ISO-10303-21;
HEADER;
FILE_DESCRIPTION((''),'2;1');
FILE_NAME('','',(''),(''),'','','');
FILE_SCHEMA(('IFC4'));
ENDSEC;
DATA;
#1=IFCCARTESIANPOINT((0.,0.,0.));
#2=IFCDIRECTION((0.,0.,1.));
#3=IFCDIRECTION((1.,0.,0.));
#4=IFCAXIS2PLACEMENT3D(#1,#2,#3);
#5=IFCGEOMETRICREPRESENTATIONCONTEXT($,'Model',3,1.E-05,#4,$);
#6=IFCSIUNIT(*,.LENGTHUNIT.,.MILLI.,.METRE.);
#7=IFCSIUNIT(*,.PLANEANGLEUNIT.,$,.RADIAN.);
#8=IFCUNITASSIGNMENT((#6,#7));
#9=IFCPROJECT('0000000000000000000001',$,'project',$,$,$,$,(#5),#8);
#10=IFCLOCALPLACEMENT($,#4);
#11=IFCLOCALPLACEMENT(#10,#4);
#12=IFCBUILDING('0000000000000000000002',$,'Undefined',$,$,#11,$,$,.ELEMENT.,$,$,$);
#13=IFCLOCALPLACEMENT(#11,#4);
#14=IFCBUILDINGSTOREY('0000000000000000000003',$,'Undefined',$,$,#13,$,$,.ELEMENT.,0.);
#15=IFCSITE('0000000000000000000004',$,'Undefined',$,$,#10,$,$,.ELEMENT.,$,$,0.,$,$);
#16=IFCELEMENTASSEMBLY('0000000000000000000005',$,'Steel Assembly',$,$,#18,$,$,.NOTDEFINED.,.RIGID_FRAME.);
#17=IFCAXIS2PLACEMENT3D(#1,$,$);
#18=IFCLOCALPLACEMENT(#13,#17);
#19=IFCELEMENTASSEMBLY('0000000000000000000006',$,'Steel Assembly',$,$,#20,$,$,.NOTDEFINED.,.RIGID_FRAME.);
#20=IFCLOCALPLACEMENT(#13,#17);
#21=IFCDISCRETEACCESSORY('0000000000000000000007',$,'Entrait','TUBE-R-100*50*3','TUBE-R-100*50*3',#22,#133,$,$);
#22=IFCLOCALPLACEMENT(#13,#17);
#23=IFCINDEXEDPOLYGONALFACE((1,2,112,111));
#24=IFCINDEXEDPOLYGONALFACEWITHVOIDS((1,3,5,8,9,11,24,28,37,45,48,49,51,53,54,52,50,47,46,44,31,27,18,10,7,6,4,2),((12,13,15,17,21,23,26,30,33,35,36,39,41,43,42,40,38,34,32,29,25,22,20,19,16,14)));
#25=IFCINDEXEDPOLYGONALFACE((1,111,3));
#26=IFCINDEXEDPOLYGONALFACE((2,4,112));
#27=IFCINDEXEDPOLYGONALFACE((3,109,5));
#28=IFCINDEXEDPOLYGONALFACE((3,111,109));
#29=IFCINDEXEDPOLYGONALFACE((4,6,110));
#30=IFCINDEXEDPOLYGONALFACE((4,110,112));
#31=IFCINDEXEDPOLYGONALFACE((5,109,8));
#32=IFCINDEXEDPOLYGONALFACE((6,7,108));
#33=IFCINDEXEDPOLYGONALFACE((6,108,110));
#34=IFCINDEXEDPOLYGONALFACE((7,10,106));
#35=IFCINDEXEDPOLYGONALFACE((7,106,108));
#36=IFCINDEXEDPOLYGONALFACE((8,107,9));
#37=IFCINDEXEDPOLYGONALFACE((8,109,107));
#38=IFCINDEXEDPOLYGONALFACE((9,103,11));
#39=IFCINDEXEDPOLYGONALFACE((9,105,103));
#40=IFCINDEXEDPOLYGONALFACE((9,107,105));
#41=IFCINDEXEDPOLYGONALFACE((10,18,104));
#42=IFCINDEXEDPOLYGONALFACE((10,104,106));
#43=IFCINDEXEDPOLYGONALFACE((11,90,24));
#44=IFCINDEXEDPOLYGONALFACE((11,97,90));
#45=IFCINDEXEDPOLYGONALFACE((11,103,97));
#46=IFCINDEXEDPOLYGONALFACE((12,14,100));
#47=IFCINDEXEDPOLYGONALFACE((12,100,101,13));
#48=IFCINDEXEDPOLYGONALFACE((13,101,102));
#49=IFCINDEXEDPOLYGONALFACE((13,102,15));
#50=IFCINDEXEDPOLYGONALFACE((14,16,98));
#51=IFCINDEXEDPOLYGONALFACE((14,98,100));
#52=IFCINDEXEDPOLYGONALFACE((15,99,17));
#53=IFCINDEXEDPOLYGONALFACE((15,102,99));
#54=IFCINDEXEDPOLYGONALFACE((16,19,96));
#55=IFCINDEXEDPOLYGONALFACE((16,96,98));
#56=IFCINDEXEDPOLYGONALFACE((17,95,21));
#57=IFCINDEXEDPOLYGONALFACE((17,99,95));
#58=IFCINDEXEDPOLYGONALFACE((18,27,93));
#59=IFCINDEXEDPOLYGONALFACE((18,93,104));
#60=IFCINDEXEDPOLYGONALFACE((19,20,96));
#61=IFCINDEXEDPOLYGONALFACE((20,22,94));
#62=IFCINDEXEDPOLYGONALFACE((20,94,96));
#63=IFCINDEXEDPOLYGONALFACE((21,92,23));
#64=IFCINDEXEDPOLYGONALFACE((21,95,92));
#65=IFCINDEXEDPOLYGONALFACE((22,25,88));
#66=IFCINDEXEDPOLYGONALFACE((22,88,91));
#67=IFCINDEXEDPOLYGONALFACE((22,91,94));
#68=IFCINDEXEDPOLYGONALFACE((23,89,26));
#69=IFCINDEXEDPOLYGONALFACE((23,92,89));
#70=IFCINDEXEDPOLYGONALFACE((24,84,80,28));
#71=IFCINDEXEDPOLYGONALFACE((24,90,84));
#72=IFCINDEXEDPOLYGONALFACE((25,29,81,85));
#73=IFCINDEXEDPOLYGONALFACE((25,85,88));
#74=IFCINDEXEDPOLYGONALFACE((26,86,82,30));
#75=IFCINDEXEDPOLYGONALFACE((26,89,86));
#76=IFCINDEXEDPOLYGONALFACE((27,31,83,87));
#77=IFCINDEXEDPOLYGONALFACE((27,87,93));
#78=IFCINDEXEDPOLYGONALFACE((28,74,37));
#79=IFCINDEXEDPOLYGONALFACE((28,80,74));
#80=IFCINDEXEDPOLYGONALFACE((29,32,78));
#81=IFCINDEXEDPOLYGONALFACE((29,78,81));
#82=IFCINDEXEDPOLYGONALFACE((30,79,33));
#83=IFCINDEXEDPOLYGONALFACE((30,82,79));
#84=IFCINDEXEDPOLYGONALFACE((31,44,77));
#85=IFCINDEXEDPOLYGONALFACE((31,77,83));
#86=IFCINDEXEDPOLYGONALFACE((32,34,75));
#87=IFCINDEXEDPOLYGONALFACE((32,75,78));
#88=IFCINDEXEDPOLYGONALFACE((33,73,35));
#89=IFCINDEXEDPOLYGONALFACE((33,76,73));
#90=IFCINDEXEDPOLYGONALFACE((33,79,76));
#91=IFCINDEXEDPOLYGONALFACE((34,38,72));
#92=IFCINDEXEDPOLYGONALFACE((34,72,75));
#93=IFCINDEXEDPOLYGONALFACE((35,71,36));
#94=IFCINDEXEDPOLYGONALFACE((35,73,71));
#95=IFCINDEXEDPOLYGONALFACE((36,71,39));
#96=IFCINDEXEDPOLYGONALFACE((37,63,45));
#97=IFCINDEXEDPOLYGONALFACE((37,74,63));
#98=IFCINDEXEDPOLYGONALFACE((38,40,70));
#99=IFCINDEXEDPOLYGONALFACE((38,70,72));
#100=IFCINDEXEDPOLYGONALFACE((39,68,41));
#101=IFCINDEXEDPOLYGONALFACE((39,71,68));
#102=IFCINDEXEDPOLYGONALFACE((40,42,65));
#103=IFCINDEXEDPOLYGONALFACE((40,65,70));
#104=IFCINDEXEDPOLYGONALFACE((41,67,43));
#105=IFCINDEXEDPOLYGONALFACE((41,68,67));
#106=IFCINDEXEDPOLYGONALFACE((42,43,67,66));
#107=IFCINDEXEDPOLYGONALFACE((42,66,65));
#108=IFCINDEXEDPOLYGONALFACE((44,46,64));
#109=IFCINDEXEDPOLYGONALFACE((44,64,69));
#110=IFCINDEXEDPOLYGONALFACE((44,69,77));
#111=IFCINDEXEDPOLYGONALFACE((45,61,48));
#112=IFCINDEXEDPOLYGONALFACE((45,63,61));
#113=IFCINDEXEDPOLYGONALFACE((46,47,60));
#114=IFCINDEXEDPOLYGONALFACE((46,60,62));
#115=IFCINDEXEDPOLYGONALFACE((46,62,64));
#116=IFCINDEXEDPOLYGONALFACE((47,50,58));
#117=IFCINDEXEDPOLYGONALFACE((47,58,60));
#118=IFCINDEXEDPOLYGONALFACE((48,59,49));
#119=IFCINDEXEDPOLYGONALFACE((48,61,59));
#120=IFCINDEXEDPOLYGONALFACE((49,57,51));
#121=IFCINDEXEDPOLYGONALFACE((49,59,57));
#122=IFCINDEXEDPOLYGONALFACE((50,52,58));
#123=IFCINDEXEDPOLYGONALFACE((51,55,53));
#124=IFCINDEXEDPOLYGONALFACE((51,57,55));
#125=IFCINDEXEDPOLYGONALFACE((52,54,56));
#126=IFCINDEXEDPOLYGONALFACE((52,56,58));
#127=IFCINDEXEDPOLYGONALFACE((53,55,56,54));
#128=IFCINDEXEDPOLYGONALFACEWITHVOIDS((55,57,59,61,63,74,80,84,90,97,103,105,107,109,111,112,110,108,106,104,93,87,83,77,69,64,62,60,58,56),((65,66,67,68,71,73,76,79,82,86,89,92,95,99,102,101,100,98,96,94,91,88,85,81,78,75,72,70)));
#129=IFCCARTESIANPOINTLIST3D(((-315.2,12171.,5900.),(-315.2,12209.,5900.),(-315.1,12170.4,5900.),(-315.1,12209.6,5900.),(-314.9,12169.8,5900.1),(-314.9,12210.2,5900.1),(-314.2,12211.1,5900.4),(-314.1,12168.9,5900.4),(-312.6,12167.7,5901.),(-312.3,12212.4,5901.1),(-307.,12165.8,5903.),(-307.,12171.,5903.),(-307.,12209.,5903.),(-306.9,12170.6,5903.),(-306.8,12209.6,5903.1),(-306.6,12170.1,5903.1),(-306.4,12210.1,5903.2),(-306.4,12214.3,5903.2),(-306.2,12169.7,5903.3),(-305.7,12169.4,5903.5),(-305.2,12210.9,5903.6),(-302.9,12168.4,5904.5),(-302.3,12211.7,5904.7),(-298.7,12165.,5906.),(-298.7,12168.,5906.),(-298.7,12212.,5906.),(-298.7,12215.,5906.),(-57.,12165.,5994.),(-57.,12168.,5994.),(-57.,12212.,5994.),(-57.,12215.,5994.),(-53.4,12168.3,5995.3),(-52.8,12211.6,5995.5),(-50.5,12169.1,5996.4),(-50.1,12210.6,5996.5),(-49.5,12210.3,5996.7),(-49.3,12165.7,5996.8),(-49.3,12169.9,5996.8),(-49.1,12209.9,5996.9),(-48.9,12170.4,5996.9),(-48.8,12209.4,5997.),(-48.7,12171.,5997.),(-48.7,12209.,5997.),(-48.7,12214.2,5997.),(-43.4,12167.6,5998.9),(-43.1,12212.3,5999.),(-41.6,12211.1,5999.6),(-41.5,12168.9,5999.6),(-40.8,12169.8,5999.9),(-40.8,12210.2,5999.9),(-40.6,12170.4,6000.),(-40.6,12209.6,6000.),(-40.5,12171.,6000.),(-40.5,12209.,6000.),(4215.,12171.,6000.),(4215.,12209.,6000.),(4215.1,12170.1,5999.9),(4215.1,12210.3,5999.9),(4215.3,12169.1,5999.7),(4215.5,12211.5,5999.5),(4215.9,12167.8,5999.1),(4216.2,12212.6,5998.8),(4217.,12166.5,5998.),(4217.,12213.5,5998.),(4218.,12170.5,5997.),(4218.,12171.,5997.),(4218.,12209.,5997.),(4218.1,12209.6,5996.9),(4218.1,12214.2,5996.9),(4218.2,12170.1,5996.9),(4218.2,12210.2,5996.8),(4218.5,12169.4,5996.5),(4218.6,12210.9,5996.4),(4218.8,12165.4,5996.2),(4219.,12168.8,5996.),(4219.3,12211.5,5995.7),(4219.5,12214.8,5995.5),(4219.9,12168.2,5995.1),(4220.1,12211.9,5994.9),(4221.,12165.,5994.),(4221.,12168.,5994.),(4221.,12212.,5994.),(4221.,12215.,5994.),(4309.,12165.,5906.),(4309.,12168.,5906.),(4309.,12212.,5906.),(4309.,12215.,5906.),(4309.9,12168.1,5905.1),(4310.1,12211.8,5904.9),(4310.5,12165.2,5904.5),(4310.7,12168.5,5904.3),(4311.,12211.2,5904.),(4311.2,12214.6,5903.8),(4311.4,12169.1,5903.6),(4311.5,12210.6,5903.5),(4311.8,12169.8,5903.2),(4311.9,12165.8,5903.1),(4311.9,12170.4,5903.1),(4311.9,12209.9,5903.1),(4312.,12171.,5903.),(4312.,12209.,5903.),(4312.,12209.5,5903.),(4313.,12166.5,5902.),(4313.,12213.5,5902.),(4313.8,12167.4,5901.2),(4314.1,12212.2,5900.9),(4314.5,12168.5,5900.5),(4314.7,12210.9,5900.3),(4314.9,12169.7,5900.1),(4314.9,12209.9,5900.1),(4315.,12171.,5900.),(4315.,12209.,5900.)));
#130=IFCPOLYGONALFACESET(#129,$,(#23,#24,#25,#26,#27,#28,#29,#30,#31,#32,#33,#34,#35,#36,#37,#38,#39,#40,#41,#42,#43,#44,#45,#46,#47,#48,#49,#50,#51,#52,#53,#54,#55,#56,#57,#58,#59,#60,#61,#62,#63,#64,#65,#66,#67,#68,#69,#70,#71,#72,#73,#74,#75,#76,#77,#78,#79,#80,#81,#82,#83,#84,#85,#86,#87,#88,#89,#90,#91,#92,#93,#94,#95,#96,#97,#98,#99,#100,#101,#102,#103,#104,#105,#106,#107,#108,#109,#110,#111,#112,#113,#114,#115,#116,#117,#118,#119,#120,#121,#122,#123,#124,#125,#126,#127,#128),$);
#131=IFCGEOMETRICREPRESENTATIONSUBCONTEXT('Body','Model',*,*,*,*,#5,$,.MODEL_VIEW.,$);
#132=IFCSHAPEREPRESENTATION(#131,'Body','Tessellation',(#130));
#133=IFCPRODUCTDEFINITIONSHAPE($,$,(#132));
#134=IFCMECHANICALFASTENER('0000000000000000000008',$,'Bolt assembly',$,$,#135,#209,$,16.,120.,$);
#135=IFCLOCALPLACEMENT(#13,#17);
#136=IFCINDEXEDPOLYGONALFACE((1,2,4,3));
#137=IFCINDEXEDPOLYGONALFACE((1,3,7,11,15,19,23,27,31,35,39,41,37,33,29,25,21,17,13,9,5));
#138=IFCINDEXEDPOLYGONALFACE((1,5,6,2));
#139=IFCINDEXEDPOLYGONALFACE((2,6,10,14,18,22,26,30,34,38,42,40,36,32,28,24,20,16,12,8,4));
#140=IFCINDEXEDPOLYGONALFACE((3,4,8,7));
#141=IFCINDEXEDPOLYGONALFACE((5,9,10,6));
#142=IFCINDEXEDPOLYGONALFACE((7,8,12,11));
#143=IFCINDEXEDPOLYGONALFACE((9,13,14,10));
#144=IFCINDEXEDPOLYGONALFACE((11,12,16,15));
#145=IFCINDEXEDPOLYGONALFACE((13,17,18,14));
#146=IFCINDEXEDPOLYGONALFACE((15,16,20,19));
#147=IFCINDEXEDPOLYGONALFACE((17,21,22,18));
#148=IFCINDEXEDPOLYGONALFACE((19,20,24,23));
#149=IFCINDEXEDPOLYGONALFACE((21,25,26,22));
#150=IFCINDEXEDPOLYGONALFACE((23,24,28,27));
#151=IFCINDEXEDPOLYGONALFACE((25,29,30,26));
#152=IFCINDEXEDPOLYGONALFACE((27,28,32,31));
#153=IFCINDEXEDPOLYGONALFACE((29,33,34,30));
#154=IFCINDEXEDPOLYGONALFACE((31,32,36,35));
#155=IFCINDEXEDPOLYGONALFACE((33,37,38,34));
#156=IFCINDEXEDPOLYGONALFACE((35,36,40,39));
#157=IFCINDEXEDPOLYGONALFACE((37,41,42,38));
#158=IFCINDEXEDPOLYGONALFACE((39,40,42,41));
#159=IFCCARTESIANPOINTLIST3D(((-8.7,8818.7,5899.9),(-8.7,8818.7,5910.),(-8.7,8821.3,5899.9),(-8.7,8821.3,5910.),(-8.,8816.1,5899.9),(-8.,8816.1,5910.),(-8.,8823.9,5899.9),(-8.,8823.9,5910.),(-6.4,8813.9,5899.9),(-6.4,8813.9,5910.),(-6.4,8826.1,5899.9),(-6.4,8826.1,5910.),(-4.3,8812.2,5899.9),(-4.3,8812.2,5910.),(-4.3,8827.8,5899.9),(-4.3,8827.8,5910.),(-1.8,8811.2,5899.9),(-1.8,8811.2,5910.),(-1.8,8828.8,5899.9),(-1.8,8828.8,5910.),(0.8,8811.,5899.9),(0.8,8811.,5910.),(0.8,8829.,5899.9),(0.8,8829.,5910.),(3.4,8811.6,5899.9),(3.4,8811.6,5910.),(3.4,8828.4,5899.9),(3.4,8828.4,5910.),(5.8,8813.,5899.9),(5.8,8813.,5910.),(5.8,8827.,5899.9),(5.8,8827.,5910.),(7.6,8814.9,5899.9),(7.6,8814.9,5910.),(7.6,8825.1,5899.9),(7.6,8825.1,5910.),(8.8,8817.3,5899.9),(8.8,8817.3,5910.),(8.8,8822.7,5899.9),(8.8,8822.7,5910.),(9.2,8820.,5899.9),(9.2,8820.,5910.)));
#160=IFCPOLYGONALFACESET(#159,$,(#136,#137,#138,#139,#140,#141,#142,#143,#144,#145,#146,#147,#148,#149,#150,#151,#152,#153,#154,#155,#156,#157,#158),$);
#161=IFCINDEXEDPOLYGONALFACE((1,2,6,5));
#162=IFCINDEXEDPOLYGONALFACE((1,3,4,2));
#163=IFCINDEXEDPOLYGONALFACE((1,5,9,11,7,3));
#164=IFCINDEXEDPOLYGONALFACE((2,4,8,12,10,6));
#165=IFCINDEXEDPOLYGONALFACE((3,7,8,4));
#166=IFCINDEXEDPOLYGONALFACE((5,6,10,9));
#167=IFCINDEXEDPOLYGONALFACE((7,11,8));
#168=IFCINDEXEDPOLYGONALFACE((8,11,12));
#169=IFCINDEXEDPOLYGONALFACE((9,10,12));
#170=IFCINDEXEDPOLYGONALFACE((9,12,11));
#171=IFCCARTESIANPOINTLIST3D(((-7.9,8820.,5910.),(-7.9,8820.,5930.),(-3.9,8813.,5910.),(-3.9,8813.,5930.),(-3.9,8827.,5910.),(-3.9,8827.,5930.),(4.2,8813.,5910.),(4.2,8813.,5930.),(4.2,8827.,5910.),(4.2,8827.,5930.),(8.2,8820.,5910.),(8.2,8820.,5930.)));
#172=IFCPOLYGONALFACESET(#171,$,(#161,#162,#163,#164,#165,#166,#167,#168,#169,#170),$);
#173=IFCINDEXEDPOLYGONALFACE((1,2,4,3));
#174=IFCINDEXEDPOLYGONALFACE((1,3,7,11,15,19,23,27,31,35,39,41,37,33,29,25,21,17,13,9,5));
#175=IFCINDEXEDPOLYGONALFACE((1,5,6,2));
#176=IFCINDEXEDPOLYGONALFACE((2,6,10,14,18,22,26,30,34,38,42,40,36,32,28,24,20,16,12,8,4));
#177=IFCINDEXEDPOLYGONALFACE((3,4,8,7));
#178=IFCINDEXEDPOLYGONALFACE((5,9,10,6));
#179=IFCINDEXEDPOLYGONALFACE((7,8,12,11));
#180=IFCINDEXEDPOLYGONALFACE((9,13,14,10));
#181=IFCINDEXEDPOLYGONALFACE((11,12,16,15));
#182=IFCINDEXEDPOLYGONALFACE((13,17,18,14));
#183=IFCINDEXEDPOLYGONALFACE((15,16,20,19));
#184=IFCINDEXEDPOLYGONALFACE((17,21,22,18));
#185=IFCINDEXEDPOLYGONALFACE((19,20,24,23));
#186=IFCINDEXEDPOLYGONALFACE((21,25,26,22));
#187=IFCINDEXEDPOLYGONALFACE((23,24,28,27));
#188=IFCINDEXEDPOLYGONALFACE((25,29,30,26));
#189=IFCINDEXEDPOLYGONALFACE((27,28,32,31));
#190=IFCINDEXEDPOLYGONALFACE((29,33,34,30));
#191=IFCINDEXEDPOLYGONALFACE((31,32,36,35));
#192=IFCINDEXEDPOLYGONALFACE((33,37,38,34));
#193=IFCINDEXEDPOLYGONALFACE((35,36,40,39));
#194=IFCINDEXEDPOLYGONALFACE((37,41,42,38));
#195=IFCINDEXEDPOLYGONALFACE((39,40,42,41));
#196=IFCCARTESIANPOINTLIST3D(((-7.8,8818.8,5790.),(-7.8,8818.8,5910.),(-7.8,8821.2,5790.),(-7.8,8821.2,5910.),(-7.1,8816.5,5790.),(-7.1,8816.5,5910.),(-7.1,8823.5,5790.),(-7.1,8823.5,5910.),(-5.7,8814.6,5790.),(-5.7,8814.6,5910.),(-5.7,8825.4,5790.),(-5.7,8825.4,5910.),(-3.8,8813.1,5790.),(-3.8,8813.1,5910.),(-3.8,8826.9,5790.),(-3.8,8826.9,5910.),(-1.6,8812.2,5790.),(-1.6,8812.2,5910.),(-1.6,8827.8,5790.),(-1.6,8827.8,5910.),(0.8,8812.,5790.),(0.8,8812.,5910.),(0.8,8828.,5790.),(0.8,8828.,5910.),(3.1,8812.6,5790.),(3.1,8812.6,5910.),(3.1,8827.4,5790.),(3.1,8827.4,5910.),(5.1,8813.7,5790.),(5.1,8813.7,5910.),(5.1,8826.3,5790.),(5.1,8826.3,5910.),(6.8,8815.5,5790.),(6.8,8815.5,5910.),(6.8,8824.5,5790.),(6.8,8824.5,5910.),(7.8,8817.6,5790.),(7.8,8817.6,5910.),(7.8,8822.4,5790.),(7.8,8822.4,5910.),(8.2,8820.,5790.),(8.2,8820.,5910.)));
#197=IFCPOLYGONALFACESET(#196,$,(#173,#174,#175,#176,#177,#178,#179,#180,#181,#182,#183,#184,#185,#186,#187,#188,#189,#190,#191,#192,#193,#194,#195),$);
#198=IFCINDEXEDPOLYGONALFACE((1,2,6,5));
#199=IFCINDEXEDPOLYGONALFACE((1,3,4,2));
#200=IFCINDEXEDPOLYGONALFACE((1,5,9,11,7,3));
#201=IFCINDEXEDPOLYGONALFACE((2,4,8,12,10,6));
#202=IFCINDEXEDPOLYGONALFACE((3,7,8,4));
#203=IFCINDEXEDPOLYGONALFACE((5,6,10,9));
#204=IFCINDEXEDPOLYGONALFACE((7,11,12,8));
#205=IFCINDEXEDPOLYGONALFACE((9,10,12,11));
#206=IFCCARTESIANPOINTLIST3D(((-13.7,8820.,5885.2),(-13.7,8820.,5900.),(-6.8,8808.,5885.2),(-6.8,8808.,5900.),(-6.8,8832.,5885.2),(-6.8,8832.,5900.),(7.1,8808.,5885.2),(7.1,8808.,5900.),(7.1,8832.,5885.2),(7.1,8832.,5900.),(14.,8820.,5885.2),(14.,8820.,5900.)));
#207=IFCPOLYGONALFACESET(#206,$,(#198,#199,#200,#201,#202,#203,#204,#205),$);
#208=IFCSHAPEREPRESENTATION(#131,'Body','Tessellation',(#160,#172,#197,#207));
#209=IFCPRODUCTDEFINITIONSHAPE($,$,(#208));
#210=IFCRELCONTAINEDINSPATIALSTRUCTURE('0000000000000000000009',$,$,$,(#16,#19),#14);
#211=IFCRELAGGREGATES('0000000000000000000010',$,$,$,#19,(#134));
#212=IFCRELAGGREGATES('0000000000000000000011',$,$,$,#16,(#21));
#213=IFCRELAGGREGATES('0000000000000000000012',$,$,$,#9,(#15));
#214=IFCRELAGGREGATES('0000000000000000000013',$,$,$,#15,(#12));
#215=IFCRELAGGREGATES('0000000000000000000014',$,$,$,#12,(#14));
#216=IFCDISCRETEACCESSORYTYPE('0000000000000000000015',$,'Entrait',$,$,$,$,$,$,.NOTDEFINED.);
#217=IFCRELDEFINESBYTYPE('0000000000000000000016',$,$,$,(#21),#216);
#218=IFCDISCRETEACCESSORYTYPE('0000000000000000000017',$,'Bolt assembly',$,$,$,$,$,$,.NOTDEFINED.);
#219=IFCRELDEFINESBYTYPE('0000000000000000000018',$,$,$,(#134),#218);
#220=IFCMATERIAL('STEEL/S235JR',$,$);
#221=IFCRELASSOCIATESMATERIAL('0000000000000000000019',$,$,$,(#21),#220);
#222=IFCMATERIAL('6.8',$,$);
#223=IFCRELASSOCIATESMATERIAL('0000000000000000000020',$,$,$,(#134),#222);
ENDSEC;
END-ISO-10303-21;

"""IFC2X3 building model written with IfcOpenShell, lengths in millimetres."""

from ifc_helpers import new_model, si_unit, frame, origin_with_axes, origin_2d_with_axis, place, context, subcontext, project, spatial, polyline, hollow_rectangle, circle, outline, extrude, clip, halfspace, source, transform, mapped, material, type_object, element, aggregate, save


model = new_model("IFC2X3")

# Units and contexts
model_context = context("Model", 3, precision=1e-05, world=origin_with_axes())
body_context = subcontext(model_context, "Body", "Model", "MODEL_VIEW")
ifc_project = project(units=[si_unit("LENGTHUNIT", "METRE", prefix="MILLI"), si_unit("PLANEANGLEUNIT", "RADIAN")], contexts=[model_context])

# Site, building, storey
site_placement = place(None, origin_with_axes())
site = spatial("IfcSite", under=ifc_project, at=site_placement, Name="Undefined", CompositionType="ELEMENT", RefElevation=0.0)
building_placement = place(site_placement, origin_with_axes())
building = spatial("IfcBuilding", under=site, at=building_placement, Name="Undefined", CompositionType="ELEMENT")
storey_placement = place(building_placement, origin_with_axes())
storey = spatial("IfcBuildingStorey", under=building, at=storey_placement, Name="Undefined", CompositionType="ELEMENT", Elevation=0.0)

# Shared definitions
ifc_material_1 = material(Name="STEEL/S235JR")

# Element assembly
assembly_1_placement = place(storey_placement, origin_with_axes())
assembly_1 = element("IfcElementAssembly", 1, at=assembly_1_placement, inside=storey, Name="Steel Assembly", AssemblyPlace="NOTDEFINED", PredefinedType="RIGID_FRAME")

# Element assembly
assembly_2_placement = place(storey_placement, origin_with_axes())
assembly_2 = element("IfcElementAssembly", 2, at=assembly_2_placement, inside=storey, Name="Steel Assembly", AssemblyPlace="NOTDEFINED", PredefinedType="RIGID_FRAME")

# Discrete accessory
discrete_accessory_type_1 = type_object("IfcDiscreteAccessoryType", Name="Entrait")
discrete_accessory_1_placement = place(assembly_1_placement, frame((-404.2, 12190.0, 5950.0), z_axis=(0.0, 0.0, 1.0), x_axis=(1.0, 0.0, 0.0)))
discrete_accessory_1 = element("IfcDiscreteAccessory", 3, at=discrete_accessory_1_placement, type_object=discrete_accessory_type_1, material=ifc_material_1, Name="Entrait", Description="TUBE-R-100*50*3", ObjectType="TUBE-R-100*50*3", context=body_context, shape_type="Clipping", body=[
    clip(clip(extrude(hollow_rectangle(XDim=50.0, YDim=100.0, WallThickness=3.0, InnerFilletRadius=3.0, OuterFilletRadius=6.0, at=origin_2d_with_axis()), frame((4858.5, 0.0, 0.0), z_axis=(-1.0, 0.0, 0.0), x_axis=(0.0, -1.0, 0.0)), (0.0, 0.0, 1.0), 4821.4), halfspace(frame((4619.2, 0.0, 50.0), z_axis=(-0.707107, 0.0, -0.707107), x_axis=(0.0, -1.0, 0.0)), True)), halfspace(frame((115.1, 0.0, -40.5), z_axis=(0.34202, 0.0, -0.939693), x_axis=(0.0, -1.0, 0.0)), True)),
])

# Mechanical fastener
ifc_material_2 = material(Name="6.8")
discrete_accessory_type_2 = type_object("IfcDiscreteAccessoryType", Name="Bolt assembly")
shared_shape_1 = source(origin_with_axes(), body_context, "Body", "SweptSolid", [
    extrude(circle(Radius=9.0, at=origin_2d_with_axis()), frame((0.0, -10.0, 0.0), z_axis=(0.0, 1.0, 0.0), x_axis=(1.0, 0.0, 0.0)), (0.0, 0.0, 1.0), 10.1),
    extrude(outline(polyline([(8.1, 0.0), (4.0, 7.0), (-4.0, 7.0), (-8.1, 0.0), (-4.0, -7.0), (4.0, -7.0), (8.1, 0.0)])), frame((0.0, -30.0, 0.0), z_axis=(0.0, 1.0, 0.0), x_axis=(1.0, 0.0, 0.0)), (0.0, 0.0, 1.0), 20.0),
    extrude(circle(Radius=8.0, at=origin_2d_with_axis()), frame((0.0, -10.0, 0.0), z_axis=(0.0, 1.0, 0.0), x_axis=(1.0, 0.0, 0.0)), (0.0, 0.0, 1.0), 120.0),
    extrude(outline(polyline([(13.9, 0.0), (6.9, 12.0), (-6.9, 12.0), (-13.9, 0.0), (-6.9, -12.0), (6.9, -12.0), (13.9, 0.0)])), frame((0.0, 0.0, 0.0), z_axis=(0.0, 1.0, 0.0), x_axis=(1.0, 0.0, 0.0)), (0.0, 0.0, 1.0), 14.8),
])
mechanical_fastener_1_placement = place(assembly_2_placement, frame((0.2, 8820.0, 5900.0), z_axis=(0.0, 1.0, 0.0), x_axis=(1.0, 0.0, 0.0)))
mechanical_fastener_1 = element("IfcMechanicalFastener", 4, at=mechanical_fastener_1_placement, type_object=discrete_accessory_type_2, material=ifc_material_2, Name="Bolt assembly", NominalDiameter=16.0, NominalLength=120.0, context=body_context, shape_type="MappedRepresentation", body=[
    mapped(shared_shape_1, transform((0.0, 0.0, 0.0))),
])
aggregate(assembly_2, [mechanical_fastener_1])
aggregate(assembly_1, [discrete_accessory_1])

save(model, "model.ifc")
